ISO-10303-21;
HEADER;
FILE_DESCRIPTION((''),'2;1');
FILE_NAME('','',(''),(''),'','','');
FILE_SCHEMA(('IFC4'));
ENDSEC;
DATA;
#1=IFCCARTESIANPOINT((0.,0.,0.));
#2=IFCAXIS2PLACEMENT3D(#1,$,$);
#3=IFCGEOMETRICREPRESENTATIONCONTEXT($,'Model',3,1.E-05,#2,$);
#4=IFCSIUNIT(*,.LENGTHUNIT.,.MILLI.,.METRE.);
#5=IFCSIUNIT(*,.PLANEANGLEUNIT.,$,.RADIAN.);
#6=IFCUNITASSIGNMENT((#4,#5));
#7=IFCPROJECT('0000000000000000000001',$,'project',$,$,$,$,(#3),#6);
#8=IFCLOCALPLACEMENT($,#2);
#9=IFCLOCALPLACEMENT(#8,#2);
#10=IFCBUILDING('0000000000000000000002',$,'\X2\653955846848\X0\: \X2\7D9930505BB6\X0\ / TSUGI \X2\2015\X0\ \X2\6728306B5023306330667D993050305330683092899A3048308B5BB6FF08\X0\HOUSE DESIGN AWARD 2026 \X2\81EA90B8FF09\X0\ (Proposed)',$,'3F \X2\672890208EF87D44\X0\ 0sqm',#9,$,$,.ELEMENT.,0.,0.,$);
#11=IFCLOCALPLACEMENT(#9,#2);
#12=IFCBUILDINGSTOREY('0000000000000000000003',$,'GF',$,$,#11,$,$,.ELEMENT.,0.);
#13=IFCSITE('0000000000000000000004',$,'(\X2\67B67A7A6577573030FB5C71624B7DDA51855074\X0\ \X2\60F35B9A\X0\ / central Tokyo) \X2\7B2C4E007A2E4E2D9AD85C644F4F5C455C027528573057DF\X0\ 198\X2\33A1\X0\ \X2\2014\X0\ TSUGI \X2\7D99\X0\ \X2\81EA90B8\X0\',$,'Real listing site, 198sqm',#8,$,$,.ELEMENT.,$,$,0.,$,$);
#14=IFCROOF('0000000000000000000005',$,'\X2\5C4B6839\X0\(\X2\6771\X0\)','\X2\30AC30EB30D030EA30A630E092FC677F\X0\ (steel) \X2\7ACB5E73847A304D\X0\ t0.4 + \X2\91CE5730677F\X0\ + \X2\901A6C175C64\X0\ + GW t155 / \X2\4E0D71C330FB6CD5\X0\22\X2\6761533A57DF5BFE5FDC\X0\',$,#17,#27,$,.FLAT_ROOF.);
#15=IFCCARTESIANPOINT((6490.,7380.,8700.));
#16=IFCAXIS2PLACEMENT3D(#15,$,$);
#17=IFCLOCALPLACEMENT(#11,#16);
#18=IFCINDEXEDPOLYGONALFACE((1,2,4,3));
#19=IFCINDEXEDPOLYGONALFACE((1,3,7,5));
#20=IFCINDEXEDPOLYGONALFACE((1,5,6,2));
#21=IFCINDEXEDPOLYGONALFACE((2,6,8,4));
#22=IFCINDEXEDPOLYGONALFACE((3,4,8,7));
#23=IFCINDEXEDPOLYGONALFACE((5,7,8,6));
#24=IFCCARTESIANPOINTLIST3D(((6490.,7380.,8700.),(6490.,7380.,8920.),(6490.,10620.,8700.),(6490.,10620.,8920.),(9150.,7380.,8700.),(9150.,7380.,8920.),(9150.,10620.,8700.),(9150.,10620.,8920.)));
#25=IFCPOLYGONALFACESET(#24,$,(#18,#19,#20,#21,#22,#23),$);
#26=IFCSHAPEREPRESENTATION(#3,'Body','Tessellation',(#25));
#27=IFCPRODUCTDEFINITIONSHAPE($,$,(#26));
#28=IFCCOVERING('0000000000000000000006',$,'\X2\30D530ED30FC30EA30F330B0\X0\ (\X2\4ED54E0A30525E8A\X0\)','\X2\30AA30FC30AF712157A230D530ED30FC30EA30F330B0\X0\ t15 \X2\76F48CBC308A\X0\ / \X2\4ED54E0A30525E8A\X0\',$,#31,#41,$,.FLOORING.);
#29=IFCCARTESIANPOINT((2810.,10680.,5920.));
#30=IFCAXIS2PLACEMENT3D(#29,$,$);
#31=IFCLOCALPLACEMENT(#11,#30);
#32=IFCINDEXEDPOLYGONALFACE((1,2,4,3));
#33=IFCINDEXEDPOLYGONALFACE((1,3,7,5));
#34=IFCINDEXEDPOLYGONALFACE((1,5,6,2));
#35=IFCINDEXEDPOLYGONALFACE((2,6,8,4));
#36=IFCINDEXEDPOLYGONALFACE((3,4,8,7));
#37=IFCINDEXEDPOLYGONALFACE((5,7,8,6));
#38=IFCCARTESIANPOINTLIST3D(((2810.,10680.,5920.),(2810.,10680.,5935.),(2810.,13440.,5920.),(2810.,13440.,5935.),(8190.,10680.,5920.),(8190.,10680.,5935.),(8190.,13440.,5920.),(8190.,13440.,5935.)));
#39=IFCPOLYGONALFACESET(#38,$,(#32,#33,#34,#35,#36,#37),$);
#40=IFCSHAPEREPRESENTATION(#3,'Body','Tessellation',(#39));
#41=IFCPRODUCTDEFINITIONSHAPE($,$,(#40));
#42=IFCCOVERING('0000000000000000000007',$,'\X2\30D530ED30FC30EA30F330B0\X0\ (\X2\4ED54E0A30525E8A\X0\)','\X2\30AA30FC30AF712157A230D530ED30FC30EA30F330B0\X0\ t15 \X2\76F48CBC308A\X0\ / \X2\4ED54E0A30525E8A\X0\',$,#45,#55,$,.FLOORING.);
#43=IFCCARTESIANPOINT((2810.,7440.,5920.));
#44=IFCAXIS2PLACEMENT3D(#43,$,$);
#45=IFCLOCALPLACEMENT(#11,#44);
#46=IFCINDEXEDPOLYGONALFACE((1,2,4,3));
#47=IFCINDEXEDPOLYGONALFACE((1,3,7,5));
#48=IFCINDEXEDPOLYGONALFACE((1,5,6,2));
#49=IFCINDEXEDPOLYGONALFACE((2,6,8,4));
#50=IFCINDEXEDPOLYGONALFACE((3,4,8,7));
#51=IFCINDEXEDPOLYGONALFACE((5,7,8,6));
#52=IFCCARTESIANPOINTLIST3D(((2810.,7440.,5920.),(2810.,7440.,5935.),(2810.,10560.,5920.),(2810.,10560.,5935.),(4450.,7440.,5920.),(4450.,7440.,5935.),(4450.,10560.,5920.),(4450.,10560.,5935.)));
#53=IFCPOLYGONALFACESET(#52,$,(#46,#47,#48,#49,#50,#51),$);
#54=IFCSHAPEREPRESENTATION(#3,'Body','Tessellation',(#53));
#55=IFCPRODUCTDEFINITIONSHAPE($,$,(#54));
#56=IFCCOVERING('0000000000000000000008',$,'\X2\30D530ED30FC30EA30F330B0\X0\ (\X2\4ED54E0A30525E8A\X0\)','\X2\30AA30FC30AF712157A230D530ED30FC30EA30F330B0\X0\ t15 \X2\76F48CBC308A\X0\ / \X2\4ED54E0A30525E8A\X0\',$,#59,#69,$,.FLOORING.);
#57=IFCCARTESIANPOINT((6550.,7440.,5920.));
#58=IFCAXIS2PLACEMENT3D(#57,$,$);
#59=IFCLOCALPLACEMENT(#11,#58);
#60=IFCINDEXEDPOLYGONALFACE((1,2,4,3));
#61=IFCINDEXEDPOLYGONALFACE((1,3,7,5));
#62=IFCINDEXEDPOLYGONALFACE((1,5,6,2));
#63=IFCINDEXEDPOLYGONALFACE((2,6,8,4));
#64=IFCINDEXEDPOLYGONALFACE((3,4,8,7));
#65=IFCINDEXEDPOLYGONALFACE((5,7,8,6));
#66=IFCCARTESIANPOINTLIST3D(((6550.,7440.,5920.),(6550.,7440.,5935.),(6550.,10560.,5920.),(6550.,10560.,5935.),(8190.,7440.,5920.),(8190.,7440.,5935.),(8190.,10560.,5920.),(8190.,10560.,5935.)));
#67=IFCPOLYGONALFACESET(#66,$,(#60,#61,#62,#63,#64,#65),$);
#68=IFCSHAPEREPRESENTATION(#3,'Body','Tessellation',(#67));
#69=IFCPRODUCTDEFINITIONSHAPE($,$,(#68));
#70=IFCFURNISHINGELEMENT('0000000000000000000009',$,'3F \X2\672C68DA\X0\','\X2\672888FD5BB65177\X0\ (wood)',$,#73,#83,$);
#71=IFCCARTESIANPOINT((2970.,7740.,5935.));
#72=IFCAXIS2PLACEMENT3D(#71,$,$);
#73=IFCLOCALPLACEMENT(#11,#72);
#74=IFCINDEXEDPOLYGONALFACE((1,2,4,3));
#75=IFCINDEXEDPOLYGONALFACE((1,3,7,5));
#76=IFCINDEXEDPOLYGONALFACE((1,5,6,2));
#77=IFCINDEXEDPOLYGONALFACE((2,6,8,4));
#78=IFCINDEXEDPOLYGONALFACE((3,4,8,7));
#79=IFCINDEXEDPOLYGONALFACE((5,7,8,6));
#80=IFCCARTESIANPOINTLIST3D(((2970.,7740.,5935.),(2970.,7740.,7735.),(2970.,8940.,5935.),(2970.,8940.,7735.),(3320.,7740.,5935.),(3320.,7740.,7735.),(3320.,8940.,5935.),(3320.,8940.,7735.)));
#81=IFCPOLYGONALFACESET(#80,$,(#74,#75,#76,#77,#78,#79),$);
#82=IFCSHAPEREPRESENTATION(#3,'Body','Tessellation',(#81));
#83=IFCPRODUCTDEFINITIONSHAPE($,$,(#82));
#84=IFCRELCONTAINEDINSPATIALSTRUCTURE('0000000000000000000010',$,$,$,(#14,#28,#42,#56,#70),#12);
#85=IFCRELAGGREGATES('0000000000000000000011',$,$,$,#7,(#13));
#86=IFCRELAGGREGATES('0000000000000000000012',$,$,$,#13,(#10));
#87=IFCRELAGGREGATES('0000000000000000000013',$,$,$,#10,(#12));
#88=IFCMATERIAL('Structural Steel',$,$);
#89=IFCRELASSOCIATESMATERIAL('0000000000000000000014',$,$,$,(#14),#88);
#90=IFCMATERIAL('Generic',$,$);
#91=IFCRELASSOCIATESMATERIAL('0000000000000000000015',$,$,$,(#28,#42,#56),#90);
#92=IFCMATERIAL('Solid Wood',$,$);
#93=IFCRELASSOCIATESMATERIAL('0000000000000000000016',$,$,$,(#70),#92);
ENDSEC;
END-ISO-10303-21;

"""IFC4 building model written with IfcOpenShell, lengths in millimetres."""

from ifc_helpers import new_model, si_unit, frame, frame_2d, origin, place, context, project, spatial, rectangle, extrude, material, element, save


model = new_model("IFC4")

# Units and contexts
model_context = context("Model", 3, precision=1e-05, world=origin())
ifc_project = project(units=[si_unit("LENGTHUNIT", "METRE", prefix="MILLI"), si_unit("PLANEANGLEUNIT", "RADIAN")], contexts=[model_context])

# Site, building, storey
site_placement = place(None, origin())
site = spatial("IfcSite", under=ifc_project, at=site_placement, Name="(架空敷地・山手線内側 想定 / central Tokyo) 第一種中高層住居専用地域 198㎡ — TSUGI 継 自邸", ObjectType="Real listing site, 198sqm", CompositionType="ELEMENT", RefElevation=0.0)
building_placement = place(site_placement, origin())
building = spatial("IfcBuilding", under=site, at=building_placement, Name="改善案: 継ぐ家 / TSUGI ― 木に倣って継ぐことを覚える家（HOUSE DESIGN AWARD 2026 自邸） (Proposed)", ObjectType="3F 木造軸組 0sqm", CompositionType="ELEMENT", ElevationOfRefHeight=0.0, ElevationOfTerrain=0.0)
storey_placement = place(building_placement, origin())
storey = spatial("IfcBuildingStorey", under=building, at=storey_placement, Name="GF", CompositionType="ELEMENT", Elevation=0.0)

# Shared definitions
ifc_material_1 = material(Name="Solid Wood")

# Shared definitions
ifc_material_2 = material(Name="Generic")

# Roof
ifc_material_3 = material(Name="Structural Steel")
roof_1_placement = place(storey_placement, frame((6490.0, 7380.0, 8700.0)))
element("IfcRoof", 1, at=roof_1_placement, inside=storey, material=ifc_material_3, Name="屋根(東)", Description="ガルバリウム鋼板 (steel) 立平葺き t0.4 + 野地板 + 通気層 + GW t155 / 不燃・法22条区域対応", PredefinedType="FLAT_ROOF", context=model_context, shape_type="SweptSolid", body=[
    extrude(rectangle(XDim=2660.0, YDim=3240.0, at=frame_2d((1330.0, 1620.0))), frame((6490.0, 7380.0, 8700.0)), (0.0, 0.0, 1.0), 220.0),
])

# Coverings
covering_1_placement = place(storey_placement, frame((2810.0, 10680.0, 5920.0)))
element("IfcCovering", 2, at=covering_1_placement, inside=storey, material=ifc_material_2, Name="フローリング (仕上げ床)", Description="オーク無垢フローリング t15 直貼り / 仕上げ床", PredefinedType="FLOORING", context=model_context, shape_type="SweptSolid", body=[
    extrude(rectangle(XDim=5380.0, YDim=2760.0, at=frame_2d((2690.0, 1380.0))), frame((2810.0, 10680.0, 5920.0)), (0.0, 0.0, 1.0), 15.0),
])
covering_2_placement = place(storey_placement, frame((2810.0, 7440.0, 5920.0)))
element("IfcCovering", 3, at=covering_2_placement, inside=storey, material=ifc_material_2, Name="フローリング (仕上げ床)", Description="オーク無垢フローリング t15 直貼り / 仕上げ床", PredefinedType="FLOORING", context=model_context, shape_type="SweptSolid", body=[
    extrude(rectangle(XDim=1640.0, YDim=3120.0, at=frame_2d((820.0, 1560.0))), frame((2810.0, 7440.0, 5920.0)), (0.0, 0.0, 1.0), 15.0),
])
covering_3_placement = place(storey_placement, frame((6550.0, 7440.0, 5920.0)))
element("IfcCovering", 4, at=covering_3_placement, inside=storey, material=ifc_material_2, Name="フローリング (仕上げ床)", Description="オーク無垢フローリング t15 直貼り / 仕上げ床", PredefinedType="FLOORING", context=model_context, shape_type="SweptSolid", body=[
    extrude(rectangle(XDim=1640.0, YDim=3120.0, at=frame_2d((820.0, 1560.0))), frame((6550.0, 7440.0, 5920.0)), (0.0, 0.0, 1.0), 15.0),
])

# Furnishing element
furnishing_placement = place(storey_placement, frame((2970.0, 7740.0, 5935.0)))
element("IfcFurnishingElement", 5, at=furnishing_placement, inside=storey, material=ifc_material_1, Name="3F 本棚", Description="木製家具 (wood)", context=model_context, shape_type="SweptSolid", body=[
    extrude(rectangle(XDim=350.0, YDim=1200.0, at=frame_2d((175.0, 600.0))), frame((2970.0, 7740.0, 5935.0)), (0.0, 0.0, 1.0), 1800.0),
])

save(model, "model.ifc")
